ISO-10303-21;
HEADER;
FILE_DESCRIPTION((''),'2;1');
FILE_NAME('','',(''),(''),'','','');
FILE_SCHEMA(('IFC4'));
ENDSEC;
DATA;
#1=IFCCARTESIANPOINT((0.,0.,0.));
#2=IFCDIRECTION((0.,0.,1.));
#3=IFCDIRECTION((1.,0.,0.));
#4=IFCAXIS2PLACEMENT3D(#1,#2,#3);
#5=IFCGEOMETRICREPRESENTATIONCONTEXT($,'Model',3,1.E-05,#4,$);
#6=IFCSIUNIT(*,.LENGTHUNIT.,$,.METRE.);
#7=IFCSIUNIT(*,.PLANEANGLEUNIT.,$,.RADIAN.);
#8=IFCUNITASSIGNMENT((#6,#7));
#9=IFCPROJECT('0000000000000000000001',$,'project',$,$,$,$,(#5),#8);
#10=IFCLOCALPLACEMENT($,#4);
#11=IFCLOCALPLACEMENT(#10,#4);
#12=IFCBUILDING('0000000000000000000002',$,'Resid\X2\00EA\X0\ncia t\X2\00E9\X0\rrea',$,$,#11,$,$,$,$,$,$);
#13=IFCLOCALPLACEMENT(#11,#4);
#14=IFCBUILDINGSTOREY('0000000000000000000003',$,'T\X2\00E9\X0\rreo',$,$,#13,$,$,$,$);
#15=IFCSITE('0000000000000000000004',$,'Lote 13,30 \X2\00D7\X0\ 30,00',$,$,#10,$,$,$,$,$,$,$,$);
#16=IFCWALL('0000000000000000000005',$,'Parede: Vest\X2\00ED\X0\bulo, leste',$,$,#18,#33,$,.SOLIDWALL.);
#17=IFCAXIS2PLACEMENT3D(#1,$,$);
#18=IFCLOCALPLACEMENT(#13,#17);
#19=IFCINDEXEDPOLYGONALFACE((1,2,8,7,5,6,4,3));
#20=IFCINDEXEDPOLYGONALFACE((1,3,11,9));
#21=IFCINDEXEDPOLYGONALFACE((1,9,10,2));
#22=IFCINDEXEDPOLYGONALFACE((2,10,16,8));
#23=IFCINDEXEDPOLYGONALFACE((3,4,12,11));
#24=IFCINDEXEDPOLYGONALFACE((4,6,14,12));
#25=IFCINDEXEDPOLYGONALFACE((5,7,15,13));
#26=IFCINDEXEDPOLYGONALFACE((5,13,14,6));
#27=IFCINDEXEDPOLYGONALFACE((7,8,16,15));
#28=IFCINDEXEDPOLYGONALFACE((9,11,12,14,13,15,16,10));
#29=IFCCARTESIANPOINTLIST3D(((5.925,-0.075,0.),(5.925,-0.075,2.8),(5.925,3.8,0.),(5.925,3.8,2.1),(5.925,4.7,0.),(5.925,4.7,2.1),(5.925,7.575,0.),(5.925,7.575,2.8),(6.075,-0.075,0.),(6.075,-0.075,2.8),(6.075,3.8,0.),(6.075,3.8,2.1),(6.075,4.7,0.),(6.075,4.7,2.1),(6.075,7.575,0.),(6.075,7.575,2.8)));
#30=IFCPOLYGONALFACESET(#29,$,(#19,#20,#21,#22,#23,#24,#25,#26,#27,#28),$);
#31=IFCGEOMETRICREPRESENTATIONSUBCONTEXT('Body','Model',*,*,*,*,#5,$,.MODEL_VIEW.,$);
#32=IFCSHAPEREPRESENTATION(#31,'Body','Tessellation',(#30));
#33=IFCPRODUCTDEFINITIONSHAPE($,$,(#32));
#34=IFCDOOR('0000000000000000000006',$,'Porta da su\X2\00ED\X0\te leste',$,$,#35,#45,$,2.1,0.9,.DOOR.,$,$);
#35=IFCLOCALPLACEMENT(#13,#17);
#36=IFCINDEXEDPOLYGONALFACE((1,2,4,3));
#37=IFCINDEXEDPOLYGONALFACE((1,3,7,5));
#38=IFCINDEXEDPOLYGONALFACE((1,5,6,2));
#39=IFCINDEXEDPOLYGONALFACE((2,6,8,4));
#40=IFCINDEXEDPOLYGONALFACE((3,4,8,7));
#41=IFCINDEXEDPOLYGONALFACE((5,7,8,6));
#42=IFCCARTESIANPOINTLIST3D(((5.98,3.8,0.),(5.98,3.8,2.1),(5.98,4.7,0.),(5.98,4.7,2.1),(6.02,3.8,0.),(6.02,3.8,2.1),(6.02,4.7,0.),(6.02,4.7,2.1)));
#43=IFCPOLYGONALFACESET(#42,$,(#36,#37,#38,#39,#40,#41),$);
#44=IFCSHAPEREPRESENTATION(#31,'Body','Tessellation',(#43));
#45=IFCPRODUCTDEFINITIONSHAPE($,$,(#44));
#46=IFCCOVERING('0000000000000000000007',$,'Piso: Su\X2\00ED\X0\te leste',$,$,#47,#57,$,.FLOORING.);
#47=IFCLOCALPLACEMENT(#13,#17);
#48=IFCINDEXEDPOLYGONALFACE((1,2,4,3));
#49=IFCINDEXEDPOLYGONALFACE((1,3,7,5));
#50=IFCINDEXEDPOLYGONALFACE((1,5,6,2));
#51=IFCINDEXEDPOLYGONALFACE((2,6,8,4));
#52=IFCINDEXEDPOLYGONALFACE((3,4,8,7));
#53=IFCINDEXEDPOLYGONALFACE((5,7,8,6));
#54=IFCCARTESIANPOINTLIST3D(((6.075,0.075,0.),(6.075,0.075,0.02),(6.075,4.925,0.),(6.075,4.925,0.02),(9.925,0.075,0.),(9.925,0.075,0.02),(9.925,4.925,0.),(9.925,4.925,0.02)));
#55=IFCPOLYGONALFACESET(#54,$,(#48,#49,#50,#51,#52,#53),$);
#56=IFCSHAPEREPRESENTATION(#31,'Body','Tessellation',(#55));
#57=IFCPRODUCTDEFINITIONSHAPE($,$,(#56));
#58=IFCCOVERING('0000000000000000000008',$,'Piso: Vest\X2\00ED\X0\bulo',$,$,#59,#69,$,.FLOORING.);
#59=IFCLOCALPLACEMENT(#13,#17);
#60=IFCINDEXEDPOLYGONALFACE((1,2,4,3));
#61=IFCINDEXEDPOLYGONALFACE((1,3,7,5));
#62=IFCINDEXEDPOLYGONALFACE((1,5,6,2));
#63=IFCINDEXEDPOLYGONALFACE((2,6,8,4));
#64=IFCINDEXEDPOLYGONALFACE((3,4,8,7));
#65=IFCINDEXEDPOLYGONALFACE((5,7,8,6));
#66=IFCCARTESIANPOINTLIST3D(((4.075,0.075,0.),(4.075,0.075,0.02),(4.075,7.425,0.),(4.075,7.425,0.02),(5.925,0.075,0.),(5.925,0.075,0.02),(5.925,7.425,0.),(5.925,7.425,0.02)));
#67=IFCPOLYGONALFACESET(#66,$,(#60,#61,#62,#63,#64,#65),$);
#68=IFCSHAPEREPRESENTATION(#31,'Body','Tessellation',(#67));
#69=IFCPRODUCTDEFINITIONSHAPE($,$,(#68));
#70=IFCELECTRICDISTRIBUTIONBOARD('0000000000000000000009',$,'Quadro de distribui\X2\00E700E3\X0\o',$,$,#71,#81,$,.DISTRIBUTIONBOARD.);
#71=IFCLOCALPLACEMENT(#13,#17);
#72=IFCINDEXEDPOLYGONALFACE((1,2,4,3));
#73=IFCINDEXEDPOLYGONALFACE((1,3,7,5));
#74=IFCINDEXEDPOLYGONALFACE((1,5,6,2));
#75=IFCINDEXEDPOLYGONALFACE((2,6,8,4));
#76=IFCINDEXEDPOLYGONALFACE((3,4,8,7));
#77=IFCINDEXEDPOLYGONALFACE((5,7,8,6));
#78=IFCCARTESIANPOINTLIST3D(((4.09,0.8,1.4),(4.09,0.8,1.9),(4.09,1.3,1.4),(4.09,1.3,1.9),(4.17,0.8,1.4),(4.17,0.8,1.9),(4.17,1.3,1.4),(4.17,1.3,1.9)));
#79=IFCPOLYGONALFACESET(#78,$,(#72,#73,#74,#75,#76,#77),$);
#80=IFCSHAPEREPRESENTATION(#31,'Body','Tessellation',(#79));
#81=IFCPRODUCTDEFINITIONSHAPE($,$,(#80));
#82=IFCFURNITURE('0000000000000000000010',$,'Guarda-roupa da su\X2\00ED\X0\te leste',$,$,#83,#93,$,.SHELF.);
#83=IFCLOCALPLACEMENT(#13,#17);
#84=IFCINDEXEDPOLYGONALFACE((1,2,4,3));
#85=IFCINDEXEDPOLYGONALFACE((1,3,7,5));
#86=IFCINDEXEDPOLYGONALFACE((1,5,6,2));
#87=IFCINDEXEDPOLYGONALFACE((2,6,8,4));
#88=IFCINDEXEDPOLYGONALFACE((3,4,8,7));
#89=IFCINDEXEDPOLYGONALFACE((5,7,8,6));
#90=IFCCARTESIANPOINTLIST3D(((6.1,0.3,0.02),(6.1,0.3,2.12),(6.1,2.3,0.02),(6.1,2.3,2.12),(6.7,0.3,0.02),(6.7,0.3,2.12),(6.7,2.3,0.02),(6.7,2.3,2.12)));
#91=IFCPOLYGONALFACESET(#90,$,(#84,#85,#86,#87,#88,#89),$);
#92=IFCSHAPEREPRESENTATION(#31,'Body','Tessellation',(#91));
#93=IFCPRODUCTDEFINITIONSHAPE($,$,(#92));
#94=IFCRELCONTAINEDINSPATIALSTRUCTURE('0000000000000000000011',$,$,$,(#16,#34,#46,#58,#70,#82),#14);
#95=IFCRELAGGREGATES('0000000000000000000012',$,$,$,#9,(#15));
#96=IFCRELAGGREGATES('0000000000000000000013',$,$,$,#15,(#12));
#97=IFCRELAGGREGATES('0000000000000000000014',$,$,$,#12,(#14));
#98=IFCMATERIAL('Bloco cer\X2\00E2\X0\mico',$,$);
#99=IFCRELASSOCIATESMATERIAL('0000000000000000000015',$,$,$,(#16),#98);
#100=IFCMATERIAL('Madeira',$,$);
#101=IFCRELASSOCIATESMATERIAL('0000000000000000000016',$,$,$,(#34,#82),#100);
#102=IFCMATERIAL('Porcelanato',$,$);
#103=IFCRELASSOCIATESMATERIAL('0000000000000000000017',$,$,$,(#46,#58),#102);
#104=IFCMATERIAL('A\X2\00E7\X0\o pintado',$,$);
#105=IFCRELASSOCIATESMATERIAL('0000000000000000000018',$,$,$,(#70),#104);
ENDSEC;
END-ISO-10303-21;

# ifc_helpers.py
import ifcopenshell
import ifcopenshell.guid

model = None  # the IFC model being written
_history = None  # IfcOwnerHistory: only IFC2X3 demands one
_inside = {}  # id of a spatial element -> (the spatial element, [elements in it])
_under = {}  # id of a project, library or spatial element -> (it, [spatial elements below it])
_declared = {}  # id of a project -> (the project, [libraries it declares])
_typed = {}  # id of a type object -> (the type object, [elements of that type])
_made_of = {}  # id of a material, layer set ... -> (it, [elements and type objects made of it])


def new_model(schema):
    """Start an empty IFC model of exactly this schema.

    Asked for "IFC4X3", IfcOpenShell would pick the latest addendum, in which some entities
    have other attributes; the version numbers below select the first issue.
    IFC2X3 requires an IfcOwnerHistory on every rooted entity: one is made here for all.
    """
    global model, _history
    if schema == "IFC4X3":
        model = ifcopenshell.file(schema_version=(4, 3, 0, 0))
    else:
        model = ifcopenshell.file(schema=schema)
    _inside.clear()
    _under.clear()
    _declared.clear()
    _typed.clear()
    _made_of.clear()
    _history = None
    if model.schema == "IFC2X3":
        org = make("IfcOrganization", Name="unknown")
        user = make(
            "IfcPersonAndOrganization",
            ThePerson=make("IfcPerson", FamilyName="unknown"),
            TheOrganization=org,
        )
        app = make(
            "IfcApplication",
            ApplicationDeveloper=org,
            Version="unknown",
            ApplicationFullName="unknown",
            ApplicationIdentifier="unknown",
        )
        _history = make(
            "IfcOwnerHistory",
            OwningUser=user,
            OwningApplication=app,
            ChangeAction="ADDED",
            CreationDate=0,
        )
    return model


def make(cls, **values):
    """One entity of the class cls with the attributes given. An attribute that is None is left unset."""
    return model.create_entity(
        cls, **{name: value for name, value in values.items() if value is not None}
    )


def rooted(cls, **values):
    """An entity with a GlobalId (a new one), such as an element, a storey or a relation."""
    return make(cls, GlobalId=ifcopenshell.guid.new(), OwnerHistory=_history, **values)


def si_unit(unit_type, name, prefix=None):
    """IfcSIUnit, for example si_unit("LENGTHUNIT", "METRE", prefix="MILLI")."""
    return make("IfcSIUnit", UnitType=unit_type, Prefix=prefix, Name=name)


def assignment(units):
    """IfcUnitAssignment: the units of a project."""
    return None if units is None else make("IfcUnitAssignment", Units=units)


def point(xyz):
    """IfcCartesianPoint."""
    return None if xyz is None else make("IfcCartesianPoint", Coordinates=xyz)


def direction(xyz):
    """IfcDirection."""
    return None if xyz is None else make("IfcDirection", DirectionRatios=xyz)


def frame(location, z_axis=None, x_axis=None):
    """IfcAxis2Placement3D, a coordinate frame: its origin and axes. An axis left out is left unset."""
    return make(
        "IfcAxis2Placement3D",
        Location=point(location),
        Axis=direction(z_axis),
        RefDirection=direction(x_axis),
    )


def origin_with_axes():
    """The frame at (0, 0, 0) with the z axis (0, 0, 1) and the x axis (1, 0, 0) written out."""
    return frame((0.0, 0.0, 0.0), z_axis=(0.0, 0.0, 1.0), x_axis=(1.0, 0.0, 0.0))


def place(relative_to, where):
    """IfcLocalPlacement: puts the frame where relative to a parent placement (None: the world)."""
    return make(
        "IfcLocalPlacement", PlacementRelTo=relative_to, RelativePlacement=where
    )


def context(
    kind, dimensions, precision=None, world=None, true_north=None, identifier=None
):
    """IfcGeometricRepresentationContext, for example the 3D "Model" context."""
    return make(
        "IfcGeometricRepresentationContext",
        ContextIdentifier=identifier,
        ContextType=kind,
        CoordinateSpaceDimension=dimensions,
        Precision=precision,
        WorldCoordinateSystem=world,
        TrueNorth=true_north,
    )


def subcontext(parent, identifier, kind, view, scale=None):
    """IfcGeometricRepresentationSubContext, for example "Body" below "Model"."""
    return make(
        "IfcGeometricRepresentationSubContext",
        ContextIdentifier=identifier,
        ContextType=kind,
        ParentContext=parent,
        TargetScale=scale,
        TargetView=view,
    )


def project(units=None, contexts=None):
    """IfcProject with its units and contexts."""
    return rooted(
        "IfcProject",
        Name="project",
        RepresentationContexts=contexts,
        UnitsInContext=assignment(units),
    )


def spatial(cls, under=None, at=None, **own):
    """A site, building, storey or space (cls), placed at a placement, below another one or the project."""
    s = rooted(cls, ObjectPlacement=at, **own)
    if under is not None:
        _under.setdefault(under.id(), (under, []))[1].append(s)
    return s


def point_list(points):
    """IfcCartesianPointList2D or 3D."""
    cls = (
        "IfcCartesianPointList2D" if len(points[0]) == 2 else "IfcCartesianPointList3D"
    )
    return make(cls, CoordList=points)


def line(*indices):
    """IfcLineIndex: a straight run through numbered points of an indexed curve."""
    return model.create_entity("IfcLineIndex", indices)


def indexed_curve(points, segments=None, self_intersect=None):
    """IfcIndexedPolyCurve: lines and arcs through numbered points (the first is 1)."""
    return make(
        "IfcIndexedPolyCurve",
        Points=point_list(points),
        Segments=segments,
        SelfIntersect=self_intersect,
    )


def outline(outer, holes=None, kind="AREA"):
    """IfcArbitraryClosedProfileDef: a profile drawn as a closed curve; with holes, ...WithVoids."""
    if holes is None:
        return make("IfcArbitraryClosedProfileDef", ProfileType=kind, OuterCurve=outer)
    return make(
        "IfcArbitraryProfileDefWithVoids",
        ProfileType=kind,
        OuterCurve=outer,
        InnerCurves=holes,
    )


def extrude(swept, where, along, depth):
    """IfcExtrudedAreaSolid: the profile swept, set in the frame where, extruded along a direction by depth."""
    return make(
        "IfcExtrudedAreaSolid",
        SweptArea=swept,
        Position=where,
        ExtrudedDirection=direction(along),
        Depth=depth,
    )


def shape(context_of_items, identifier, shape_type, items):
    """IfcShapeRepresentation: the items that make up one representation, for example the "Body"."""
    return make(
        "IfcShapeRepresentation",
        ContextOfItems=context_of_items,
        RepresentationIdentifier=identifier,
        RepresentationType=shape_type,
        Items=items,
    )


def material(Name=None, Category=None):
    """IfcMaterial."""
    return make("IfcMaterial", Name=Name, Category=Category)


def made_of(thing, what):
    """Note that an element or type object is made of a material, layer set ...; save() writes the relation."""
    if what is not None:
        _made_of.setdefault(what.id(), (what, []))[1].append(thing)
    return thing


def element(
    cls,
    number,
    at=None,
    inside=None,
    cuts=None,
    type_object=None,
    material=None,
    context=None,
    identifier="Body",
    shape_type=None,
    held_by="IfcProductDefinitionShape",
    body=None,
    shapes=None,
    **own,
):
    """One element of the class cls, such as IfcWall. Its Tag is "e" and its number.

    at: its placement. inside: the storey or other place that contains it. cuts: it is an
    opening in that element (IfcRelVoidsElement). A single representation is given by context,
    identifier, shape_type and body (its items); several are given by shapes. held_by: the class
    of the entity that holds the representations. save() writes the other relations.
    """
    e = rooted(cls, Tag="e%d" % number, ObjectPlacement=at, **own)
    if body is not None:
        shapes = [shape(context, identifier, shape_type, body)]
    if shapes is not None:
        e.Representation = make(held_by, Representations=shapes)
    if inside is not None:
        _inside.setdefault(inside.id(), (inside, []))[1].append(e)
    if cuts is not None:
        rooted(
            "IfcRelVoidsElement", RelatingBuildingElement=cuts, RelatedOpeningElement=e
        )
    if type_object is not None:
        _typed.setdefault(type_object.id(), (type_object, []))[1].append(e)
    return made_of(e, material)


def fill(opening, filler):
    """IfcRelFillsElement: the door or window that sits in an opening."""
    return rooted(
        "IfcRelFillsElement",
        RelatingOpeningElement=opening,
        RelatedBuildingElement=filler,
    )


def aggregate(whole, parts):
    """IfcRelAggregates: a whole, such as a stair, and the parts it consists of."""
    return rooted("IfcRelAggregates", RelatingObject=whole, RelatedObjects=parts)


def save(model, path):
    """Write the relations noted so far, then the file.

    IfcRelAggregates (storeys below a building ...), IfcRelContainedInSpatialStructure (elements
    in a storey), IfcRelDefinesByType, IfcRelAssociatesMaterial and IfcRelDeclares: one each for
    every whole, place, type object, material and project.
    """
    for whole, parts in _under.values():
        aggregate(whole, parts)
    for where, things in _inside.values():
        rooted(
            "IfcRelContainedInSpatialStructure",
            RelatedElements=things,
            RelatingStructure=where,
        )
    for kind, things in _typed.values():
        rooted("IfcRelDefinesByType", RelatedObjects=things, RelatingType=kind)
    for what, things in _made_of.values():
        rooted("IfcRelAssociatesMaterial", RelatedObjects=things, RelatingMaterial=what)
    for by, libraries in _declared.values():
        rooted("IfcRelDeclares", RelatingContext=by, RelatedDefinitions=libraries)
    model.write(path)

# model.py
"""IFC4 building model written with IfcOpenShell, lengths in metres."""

from ifc_helpers import new_model, si_unit, frame, origin_with_axes, place, context, subcontext, project, spatial, line, indexed_curve, outline, extrude, material, element, fill, save


model = new_model("IFC4")

# Units and contexts
model_context = context("Model", 3, precision=1e-05, world=origin_with_axes())
body_context = subcontext(model_context, "Body", "Model", "MODEL_VIEW")
ifc_project = project(units=[si_unit("LENGTHUNIT", "METRE"), si_unit("PLANEANGLEUNIT", "RADIAN")], contexts=[model_context])

# Site, building, storey
site_placement = place(None, origin_with_axes())
site = spatial("IfcSite", under=ifc_project, at=site_placement, Name="Lote 13,30 × 30,00")
building_placement = place(site_placement, origin_with_axes())
building = spatial("IfcBuilding", under=site, at=building_placement, Name="Residência térrea")
storey_placement = place(building_placement, origin_with_axes())
storey = spatial("IfcBuildingStorey", under=building, at=storey_placement, Name="Térreo")

# Shared definitions
ifc_material_1 = material(Name="Concreto armado")

# Shared definitions
ifc_material_2 = material(Name="Bloco cerâmico")

# Wall, opening, door
ifc_material_3 = material(Name="Madeira")
wall_1_placement = place(storey_placement, frame((5.925, -0.075, 0.0), z_axis=(0.0, 0.0, 1.0), x_axis=(1.0, 0.0, 0.0)))
wall_1 = element("IfcWall", 1, at=wall_1_placement, inside=storey, material=ifc_material_2, Name="Parede: Vestíbulo, leste", PredefinedType="SOLIDWALL", context=body_context, shape_type="SweptSolid", body=[
    extrude(outline(indexed_curve([(0.0, 0.0), (0.15, 0.0), (0.15, 7.65), (0.0, 7.65)], segments=[line(1, 2, 3, 4, 1)])), origin_with_axes(), (0.0, 0.0, 1.0), 2.8),
])
opening_1_placement = place(wall_1_placement, frame((-0.05, 3.875, 0.0), z_axis=(0.0, 0.0, 1.0), x_axis=(1.0, 0.0, 0.0)))
opening_1 = element("IfcOpeningElement", 2, at=opening_1_placement, cuts=wall_1, material=ifc_material_1, PredefinedType="OPENING", context=body_context, shape_type="SweptSolid", body=[
    extrude(outline(indexed_curve([(0.0, 0.0), (0.25, 0.0), (0.25, 0.9), (0.0, 0.9)], segments=[line(1, 2, 3, 4, 1)])), origin_with_axes(), (0.0, 0.0, 1.0), 2.1),
])
door_1_placement = place(storey_placement, frame((5.98, 3.8, 0.0), z_axis=(0.0, 0.0, 1.0), x_axis=(1.0, 0.0, 0.0)))
door_1 = element("IfcDoor", 3, at=door_1_placement, inside=storey, material=ifc_material_3, Name="Porta da suíte leste", OverallHeight=2.1, OverallWidth=0.9, PredefinedType="DOOR", context=body_context, shape_type="SweptSolid", body=[
    extrude(outline(indexed_curve([(0.0, 0.0), (0.04, 0.0), (0.04, 0.9), (0.0, 0.9)], segments=[line(1, 2, 3, 4, 1)])), origin_with_axes(), (0.0, 0.0, 1.0), 2.1),
])
fill(opening_1, door_1)

# Coverings
ifc_material_4 = material(Name="Porcelanato")
covering_1_placement = place(storey_placement, frame((6.075, 0.075, 0.0), z_axis=(0.0, 0.0, 1.0), x_axis=(1.0, 0.0, 0.0)))
element("IfcCovering", 4, at=covering_1_placement, inside=storey, material=ifc_material_4, Name="Piso: Suíte leste", PredefinedType="FLOORING", context=body_context, shape_type="SweptSolid", body=[
    extrude(outline(indexed_curve([(0.0, 0.0), (3.85, 0.0), (3.85, 4.85), (0.0, 4.85)], segments=[line(1, 2, 3, 4, 1)])), origin_with_axes(), (0.0, 0.0, 1.0), 0.02),
])
covering_2_placement = place(storey_placement, frame((4.075, 0.075, 0.0), z_axis=(0.0, 0.0, 1.0), x_axis=(1.0, 0.0, 0.0)))
element("IfcCovering", 5, at=covering_2_placement, inside=storey, material=ifc_material_4, Name="Piso: Vestíbulo", PredefinedType="FLOORING", context=body_context, shape_type="SweptSolid", body=[
    extrude(outline(indexed_curve([(0.0, 0.0), (1.85, 0.0), (1.85, 7.35), (0.0, 7.35)], segments=[line(1, 2, 3, 4, 1)])), origin_with_axes(), (0.0, 0.0, 1.0), 0.02),
])

# Electric distribution board
ifc_material_5 = material(Name="Aço pintado")
electric_distribution_board_placement = place(storey_placement, frame((4.09, 0.8, 1.4), z_axis=(0.0, 0.0, 1.0), x_axis=(1.0, 0.0, 0.0)))
element("IfcElectricDistributionBoard", 6, at=electric_distribution_board_placement, inside=storey, material=ifc_material_5, Name="Quadro de distribuição", PredefinedType="DISTRIBUTIONBOARD", context=body_context, shape_type="SweptSolid", body=[
    extrude(outline(indexed_curve([(0.0, 0.0), (0.08, 0.0), (0.08, 0.5), (0.0, 0.5)], segments=[line(1, 2, 3, 4, 1)])), origin_with_axes(), (0.0, 0.0, 1.0), 0.5),
])

# Furniture
furniture_placement = place(storey_placement, frame((6.1, 0.3, 0.02), z_axis=(0.0, 0.0, 1.0), x_axis=(1.0, 0.0, 0.0)))
element("IfcFurniture", 7, at=furniture_placement, inside=storey, material=ifc_material_3, Name="Guarda-roupa da suíte leste", PredefinedType="SHELF", context=body_context, shape_type="SweptSolid", body=[
    extrude(outline(indexed_curve([(0.0, 0.0), (0.6, 0.0), (0.6, 2.0), (0.0, 2.0)], segments=[line(1, 2, 3, 4, 1)])), origin_with_axes(), (0.0, 0.0, 1.0), 2.1),
])

save(model, "model.ifc")
